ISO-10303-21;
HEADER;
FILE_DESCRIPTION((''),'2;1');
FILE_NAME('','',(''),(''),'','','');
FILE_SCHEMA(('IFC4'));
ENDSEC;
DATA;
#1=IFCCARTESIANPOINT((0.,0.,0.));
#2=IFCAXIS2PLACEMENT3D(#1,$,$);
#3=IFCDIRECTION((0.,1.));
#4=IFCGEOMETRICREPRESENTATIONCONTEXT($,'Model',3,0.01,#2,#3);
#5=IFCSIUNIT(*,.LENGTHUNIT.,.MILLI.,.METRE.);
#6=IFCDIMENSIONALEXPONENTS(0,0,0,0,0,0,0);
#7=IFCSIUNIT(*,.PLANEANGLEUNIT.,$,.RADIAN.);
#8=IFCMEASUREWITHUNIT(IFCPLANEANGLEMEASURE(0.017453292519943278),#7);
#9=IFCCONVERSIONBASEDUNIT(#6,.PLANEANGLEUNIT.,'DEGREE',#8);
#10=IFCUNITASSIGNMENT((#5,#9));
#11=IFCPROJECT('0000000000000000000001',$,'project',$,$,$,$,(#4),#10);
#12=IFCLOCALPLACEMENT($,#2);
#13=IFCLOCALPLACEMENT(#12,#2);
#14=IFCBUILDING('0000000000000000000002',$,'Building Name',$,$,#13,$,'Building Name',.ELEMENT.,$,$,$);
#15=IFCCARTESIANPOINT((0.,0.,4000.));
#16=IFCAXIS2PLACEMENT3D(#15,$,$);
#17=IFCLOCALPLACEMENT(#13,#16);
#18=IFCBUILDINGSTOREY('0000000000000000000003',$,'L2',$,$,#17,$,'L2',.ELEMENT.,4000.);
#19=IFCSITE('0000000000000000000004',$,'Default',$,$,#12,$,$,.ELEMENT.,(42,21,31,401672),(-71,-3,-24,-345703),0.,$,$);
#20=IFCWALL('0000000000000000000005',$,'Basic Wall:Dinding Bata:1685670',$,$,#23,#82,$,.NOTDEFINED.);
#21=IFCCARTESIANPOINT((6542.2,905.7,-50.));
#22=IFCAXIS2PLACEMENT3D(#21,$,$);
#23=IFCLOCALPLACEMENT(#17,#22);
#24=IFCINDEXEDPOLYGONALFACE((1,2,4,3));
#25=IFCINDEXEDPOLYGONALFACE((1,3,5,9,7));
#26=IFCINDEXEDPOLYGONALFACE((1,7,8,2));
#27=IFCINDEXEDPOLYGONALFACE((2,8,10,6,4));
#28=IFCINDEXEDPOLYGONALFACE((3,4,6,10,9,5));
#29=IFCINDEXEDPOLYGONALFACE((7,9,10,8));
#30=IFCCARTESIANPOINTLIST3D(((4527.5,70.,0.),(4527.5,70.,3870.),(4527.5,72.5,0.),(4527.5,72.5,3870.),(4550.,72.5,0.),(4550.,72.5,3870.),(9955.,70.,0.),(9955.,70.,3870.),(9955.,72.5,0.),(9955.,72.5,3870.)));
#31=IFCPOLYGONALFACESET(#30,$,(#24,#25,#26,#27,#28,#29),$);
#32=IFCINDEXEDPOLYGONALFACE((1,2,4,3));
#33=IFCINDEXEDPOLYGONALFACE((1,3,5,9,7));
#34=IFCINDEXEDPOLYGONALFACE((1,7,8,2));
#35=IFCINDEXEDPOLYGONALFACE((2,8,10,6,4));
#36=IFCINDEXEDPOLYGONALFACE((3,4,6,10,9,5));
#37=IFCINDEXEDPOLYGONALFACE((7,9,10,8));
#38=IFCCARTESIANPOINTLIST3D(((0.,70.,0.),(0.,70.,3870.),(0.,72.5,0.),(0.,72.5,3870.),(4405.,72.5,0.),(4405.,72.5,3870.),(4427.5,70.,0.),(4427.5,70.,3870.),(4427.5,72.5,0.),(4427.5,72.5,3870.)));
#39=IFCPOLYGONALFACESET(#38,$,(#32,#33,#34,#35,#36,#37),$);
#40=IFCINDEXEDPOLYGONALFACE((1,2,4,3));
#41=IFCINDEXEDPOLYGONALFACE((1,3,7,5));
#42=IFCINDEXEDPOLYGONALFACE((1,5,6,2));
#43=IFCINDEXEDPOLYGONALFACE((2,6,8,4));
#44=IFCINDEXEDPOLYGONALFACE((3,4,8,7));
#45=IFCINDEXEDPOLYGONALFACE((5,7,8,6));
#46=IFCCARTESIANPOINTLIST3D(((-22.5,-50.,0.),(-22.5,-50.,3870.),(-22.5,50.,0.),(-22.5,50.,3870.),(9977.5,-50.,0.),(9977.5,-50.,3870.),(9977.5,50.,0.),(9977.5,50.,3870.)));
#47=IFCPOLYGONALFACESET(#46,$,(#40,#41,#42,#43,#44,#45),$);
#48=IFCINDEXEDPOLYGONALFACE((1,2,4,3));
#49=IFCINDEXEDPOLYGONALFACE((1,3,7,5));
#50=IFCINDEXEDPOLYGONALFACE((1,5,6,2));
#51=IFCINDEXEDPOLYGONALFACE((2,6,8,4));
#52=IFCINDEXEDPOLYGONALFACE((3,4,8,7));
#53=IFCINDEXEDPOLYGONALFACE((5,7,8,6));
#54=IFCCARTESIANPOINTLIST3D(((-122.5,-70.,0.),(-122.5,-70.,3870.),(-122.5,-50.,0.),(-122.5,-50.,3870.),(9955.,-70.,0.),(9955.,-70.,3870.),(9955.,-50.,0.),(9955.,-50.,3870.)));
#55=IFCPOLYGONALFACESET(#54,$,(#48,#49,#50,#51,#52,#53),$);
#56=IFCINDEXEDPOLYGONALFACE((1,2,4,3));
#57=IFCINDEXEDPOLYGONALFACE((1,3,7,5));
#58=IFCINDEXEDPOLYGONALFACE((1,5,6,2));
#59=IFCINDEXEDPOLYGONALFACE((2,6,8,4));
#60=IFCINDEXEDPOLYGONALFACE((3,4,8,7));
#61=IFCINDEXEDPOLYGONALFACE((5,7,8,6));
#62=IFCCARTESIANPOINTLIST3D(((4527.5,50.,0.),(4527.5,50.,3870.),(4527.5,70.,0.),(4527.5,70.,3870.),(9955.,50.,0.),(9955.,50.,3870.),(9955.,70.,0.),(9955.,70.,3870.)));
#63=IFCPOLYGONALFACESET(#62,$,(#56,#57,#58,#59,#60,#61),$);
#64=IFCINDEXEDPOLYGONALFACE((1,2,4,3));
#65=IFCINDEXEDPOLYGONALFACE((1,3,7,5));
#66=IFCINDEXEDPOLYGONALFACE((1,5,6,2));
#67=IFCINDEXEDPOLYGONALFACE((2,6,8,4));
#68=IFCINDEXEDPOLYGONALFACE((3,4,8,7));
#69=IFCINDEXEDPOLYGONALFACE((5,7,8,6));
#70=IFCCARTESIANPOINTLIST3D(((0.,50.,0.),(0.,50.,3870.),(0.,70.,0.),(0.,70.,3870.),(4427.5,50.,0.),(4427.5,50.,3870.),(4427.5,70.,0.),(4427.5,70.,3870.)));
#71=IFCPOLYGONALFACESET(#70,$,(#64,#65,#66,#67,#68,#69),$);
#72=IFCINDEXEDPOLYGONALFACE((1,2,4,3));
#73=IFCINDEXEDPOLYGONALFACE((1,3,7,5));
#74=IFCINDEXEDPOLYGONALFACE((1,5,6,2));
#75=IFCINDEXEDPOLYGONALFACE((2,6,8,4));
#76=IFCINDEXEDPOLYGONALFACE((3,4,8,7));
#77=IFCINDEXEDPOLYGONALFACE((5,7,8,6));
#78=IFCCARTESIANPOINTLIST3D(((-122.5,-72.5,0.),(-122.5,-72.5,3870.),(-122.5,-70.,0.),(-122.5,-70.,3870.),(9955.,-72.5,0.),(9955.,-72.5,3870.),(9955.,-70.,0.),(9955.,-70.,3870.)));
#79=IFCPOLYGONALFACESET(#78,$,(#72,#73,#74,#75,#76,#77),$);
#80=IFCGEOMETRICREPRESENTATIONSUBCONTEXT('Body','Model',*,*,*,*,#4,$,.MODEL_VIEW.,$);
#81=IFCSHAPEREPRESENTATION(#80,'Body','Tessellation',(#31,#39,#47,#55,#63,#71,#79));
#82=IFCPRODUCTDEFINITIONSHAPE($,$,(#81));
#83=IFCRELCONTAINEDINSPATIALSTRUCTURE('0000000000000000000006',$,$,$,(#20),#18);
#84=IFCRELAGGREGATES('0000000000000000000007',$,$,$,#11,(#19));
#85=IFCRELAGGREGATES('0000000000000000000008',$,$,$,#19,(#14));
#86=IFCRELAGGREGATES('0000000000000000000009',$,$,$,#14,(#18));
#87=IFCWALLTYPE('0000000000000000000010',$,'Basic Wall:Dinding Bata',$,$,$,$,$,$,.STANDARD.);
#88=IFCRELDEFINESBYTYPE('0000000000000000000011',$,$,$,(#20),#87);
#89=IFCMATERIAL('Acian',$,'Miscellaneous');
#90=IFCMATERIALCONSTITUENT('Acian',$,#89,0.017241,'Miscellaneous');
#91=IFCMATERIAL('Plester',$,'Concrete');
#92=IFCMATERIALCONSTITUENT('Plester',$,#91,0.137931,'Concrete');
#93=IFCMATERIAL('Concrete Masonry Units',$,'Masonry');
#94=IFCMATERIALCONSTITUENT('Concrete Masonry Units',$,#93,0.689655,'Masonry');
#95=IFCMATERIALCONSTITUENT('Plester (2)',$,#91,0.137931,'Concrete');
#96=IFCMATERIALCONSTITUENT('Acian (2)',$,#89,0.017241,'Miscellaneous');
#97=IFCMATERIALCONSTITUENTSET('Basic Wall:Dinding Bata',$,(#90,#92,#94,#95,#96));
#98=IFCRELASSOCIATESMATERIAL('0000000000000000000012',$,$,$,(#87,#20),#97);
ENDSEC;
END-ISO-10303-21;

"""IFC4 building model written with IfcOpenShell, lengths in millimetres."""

from ifc_helpers import new_model, entity, si_unit, converted_unit, direction, frame, origin, place, context, subcontext, project, spatial, indexed_curve, outline, extrude, material, constituent, constituent_set, type_object, element, save


model = new_model("IFC4")

# Units and contexts
model_context = context("Model", 3, precision=0.01, world=origin(), true_north=direction((0.0, 1.0)))
body_context = subcontext(model_context, "Body", "Model", "MODEL_VIEW")
ifc_project = project(units=[si_unit("LENGTHUNIT", "METRE", prefix="MILLI"), converted_unit("PLANEANGLEUNIT", "DEGREE", entity("IfcPlaneAngleMeasure", 0.017453292519943278), si_unit("PLANEANGLEUNIT", "RADIAN"), dimensions=[0, 0, 0, 0, 0, 0, 0])], contexts=[model_context])

# Site, building, storey
site_placement = place(None, origin())
site = spatial("IfcSite", under=ifc_project, at=site_placement, Name="Default", CompositionType="ELEMENT", RefLatitude=(42, 21, 31, 401672), RefLongitude=(-71, -3, -24, -345703), RefElevation=0.0)
building_placement = place(site_placement, origin())
building = spatial("IfcBuilding", under=site, at=building_placement, Name="Building Name", LongName="Building Name", CompositionType="ELEMENT")
storey_placement = place(building_placement, frame((0.0, 0.0, 4000.0)))
storey = spatial("IfcBuildingStorey", under=building, at=storey_placement, Name="L2", LongName="L2", CompositionType="ELEMENT", Elevation=4000.0)

# Wall
ifc_material_1 = material(Name="Acian", Category="Miscellaneous")
ifc_constituent_1 = constituent(ifc_material_1, Name="Acian", Category="Miscellaneous", fraction=0.017241)
ifc_material_2 = material(Name="Plester", Category="Concrete")
ifc_constituent_2 = constituent(ifc_material_2, Name="Plester", Category="Concrete", fraction=0.137931)
ifc_material_3 = material(Name="Concrete Masonry Units", Category="Masonry")
ifc_constituent_3 = constituent(ifc_material_3, Name="Concrete Masonry Units", Category="Masonry", fraction=0.689655)
ifc_constituent_4 = constituent(ifc_material_2, Name="Plester (2)", Category="Concrete", fraction=0.137931)
ifc_constituent_5 = constituent(ifc_material_1, Name="Acian (2)", Category="Miscellaneous", fraction=0.017241)
ifc_constituent_set = constituent_set(constituents=[ifc_constituent_1, ifc_constituent_2, ifc_constituent_3, ifc_constituent_4, ifc_constituent_5], Name="Basic Wall:Dinding Bata")
wall_type = type_object("IfcWallType", Name="Basic Wall:Dinding Bata", PredefinedType="STANDARD", material=ifc_constituent_set)
wall_1_placement = place(storey_placement, frame((6542.2, 905.7, -50.0)))
element("IfcWall", 1, at=wall_1_placement, inside=storey, type_object=wall_type, material=ifc_constituent_set, Name="Basic Wall:Dinding Bata:1685670", PredefinedType="NOTDEFINED", context=body_context, shape_type="SweptSolid", body=[
    extrude(outline(indexed_curve([(2153.0, -1.0), (2175.5, -1.0), (2175.5, 1.5), (-3252.0, 1.5), (-3252.0, -1.0), (2153.0, -1.0)], self_intersect=False)), frame((6703.0, 71.5, 0.0), z_axis=(0.0, 0.0, 1.0), x_axis=(-1.0, 0.0, 0.0)), (0.0, 0.0, 1.0), 3870.0),
    extrude(outline(indexed_curve([(-2652.0, -1.5), (1775.5, -1.5), (1775.5, 1.0), (1753.0, 1.0), (-2652.0, 1.0), (-2652.0, -1.5)], self_intersect=False)), frame((2652.0, 71.5, 0.0)), (0.0, 0.0, 1.0), 3870.0),
    extrude(outline(indexed_curve([(-5000.0, -50.0), (5000.0, -50.0), (5000.0, 50.0), (-5000.0, 50.0), (-5000.0, -50.0)], self_intersect=False)), frame((4977.5, 0.0, 0.0)), (0.0, 0.0, 1.0), 3870.0),
    extrude(outline(indexed_curve([(-5038.7, -10.0), (5038.7, -10.0), (5038.7, 10.0), (-5038.7, 10.0), (-5038.7, -10.0)], self_intersect=False)), frame((4916.2, -60.0, 0.0)), (0.0, 0.0, 1.0), 3870.0),
    extrude(outline(indexed_curve([(-2713.8, -10.0), (2713.8, -10.0), (2713.8, 10.0), (-2713.8, 10.0), (-2713.8, -10.0)], self_intersect=False)), frame((7241.2, 60.0, 0.0), z_axis=(0.0, 0.0, 1.0), x_axis=(-1.0, 0.0, 0.0)), (0.0, 0.0, 1.0), 3870.0),
    extrude(outline(indexed_curve([(-2213.7, -10.0), (2213.7, -10.0), (2213.7, 10.0), (-2213.7, 10.0), (-2213.7, -10.0)], self_intersect=False)), frame((2213.7, 60.0, 0.0)), (0.0, 0.0, 1.0), 3870.0),
    extrude(outline(indexed_curve([(-1.3, -5038.7), (1.2, -5038.7), (1.3, 5038.7), (-1.2, 5038.7), (-1.3, -5038.7)], self_intersect=False)), frame((4916.2, -71.3, 0.0), z_axis=(0.0, 0.0, 1.0), x_axis=(0.0, 1.0, 0.0)), (0.0, 0.0, 1.0), 3870.0),
])

save(model, "model.ifc")
